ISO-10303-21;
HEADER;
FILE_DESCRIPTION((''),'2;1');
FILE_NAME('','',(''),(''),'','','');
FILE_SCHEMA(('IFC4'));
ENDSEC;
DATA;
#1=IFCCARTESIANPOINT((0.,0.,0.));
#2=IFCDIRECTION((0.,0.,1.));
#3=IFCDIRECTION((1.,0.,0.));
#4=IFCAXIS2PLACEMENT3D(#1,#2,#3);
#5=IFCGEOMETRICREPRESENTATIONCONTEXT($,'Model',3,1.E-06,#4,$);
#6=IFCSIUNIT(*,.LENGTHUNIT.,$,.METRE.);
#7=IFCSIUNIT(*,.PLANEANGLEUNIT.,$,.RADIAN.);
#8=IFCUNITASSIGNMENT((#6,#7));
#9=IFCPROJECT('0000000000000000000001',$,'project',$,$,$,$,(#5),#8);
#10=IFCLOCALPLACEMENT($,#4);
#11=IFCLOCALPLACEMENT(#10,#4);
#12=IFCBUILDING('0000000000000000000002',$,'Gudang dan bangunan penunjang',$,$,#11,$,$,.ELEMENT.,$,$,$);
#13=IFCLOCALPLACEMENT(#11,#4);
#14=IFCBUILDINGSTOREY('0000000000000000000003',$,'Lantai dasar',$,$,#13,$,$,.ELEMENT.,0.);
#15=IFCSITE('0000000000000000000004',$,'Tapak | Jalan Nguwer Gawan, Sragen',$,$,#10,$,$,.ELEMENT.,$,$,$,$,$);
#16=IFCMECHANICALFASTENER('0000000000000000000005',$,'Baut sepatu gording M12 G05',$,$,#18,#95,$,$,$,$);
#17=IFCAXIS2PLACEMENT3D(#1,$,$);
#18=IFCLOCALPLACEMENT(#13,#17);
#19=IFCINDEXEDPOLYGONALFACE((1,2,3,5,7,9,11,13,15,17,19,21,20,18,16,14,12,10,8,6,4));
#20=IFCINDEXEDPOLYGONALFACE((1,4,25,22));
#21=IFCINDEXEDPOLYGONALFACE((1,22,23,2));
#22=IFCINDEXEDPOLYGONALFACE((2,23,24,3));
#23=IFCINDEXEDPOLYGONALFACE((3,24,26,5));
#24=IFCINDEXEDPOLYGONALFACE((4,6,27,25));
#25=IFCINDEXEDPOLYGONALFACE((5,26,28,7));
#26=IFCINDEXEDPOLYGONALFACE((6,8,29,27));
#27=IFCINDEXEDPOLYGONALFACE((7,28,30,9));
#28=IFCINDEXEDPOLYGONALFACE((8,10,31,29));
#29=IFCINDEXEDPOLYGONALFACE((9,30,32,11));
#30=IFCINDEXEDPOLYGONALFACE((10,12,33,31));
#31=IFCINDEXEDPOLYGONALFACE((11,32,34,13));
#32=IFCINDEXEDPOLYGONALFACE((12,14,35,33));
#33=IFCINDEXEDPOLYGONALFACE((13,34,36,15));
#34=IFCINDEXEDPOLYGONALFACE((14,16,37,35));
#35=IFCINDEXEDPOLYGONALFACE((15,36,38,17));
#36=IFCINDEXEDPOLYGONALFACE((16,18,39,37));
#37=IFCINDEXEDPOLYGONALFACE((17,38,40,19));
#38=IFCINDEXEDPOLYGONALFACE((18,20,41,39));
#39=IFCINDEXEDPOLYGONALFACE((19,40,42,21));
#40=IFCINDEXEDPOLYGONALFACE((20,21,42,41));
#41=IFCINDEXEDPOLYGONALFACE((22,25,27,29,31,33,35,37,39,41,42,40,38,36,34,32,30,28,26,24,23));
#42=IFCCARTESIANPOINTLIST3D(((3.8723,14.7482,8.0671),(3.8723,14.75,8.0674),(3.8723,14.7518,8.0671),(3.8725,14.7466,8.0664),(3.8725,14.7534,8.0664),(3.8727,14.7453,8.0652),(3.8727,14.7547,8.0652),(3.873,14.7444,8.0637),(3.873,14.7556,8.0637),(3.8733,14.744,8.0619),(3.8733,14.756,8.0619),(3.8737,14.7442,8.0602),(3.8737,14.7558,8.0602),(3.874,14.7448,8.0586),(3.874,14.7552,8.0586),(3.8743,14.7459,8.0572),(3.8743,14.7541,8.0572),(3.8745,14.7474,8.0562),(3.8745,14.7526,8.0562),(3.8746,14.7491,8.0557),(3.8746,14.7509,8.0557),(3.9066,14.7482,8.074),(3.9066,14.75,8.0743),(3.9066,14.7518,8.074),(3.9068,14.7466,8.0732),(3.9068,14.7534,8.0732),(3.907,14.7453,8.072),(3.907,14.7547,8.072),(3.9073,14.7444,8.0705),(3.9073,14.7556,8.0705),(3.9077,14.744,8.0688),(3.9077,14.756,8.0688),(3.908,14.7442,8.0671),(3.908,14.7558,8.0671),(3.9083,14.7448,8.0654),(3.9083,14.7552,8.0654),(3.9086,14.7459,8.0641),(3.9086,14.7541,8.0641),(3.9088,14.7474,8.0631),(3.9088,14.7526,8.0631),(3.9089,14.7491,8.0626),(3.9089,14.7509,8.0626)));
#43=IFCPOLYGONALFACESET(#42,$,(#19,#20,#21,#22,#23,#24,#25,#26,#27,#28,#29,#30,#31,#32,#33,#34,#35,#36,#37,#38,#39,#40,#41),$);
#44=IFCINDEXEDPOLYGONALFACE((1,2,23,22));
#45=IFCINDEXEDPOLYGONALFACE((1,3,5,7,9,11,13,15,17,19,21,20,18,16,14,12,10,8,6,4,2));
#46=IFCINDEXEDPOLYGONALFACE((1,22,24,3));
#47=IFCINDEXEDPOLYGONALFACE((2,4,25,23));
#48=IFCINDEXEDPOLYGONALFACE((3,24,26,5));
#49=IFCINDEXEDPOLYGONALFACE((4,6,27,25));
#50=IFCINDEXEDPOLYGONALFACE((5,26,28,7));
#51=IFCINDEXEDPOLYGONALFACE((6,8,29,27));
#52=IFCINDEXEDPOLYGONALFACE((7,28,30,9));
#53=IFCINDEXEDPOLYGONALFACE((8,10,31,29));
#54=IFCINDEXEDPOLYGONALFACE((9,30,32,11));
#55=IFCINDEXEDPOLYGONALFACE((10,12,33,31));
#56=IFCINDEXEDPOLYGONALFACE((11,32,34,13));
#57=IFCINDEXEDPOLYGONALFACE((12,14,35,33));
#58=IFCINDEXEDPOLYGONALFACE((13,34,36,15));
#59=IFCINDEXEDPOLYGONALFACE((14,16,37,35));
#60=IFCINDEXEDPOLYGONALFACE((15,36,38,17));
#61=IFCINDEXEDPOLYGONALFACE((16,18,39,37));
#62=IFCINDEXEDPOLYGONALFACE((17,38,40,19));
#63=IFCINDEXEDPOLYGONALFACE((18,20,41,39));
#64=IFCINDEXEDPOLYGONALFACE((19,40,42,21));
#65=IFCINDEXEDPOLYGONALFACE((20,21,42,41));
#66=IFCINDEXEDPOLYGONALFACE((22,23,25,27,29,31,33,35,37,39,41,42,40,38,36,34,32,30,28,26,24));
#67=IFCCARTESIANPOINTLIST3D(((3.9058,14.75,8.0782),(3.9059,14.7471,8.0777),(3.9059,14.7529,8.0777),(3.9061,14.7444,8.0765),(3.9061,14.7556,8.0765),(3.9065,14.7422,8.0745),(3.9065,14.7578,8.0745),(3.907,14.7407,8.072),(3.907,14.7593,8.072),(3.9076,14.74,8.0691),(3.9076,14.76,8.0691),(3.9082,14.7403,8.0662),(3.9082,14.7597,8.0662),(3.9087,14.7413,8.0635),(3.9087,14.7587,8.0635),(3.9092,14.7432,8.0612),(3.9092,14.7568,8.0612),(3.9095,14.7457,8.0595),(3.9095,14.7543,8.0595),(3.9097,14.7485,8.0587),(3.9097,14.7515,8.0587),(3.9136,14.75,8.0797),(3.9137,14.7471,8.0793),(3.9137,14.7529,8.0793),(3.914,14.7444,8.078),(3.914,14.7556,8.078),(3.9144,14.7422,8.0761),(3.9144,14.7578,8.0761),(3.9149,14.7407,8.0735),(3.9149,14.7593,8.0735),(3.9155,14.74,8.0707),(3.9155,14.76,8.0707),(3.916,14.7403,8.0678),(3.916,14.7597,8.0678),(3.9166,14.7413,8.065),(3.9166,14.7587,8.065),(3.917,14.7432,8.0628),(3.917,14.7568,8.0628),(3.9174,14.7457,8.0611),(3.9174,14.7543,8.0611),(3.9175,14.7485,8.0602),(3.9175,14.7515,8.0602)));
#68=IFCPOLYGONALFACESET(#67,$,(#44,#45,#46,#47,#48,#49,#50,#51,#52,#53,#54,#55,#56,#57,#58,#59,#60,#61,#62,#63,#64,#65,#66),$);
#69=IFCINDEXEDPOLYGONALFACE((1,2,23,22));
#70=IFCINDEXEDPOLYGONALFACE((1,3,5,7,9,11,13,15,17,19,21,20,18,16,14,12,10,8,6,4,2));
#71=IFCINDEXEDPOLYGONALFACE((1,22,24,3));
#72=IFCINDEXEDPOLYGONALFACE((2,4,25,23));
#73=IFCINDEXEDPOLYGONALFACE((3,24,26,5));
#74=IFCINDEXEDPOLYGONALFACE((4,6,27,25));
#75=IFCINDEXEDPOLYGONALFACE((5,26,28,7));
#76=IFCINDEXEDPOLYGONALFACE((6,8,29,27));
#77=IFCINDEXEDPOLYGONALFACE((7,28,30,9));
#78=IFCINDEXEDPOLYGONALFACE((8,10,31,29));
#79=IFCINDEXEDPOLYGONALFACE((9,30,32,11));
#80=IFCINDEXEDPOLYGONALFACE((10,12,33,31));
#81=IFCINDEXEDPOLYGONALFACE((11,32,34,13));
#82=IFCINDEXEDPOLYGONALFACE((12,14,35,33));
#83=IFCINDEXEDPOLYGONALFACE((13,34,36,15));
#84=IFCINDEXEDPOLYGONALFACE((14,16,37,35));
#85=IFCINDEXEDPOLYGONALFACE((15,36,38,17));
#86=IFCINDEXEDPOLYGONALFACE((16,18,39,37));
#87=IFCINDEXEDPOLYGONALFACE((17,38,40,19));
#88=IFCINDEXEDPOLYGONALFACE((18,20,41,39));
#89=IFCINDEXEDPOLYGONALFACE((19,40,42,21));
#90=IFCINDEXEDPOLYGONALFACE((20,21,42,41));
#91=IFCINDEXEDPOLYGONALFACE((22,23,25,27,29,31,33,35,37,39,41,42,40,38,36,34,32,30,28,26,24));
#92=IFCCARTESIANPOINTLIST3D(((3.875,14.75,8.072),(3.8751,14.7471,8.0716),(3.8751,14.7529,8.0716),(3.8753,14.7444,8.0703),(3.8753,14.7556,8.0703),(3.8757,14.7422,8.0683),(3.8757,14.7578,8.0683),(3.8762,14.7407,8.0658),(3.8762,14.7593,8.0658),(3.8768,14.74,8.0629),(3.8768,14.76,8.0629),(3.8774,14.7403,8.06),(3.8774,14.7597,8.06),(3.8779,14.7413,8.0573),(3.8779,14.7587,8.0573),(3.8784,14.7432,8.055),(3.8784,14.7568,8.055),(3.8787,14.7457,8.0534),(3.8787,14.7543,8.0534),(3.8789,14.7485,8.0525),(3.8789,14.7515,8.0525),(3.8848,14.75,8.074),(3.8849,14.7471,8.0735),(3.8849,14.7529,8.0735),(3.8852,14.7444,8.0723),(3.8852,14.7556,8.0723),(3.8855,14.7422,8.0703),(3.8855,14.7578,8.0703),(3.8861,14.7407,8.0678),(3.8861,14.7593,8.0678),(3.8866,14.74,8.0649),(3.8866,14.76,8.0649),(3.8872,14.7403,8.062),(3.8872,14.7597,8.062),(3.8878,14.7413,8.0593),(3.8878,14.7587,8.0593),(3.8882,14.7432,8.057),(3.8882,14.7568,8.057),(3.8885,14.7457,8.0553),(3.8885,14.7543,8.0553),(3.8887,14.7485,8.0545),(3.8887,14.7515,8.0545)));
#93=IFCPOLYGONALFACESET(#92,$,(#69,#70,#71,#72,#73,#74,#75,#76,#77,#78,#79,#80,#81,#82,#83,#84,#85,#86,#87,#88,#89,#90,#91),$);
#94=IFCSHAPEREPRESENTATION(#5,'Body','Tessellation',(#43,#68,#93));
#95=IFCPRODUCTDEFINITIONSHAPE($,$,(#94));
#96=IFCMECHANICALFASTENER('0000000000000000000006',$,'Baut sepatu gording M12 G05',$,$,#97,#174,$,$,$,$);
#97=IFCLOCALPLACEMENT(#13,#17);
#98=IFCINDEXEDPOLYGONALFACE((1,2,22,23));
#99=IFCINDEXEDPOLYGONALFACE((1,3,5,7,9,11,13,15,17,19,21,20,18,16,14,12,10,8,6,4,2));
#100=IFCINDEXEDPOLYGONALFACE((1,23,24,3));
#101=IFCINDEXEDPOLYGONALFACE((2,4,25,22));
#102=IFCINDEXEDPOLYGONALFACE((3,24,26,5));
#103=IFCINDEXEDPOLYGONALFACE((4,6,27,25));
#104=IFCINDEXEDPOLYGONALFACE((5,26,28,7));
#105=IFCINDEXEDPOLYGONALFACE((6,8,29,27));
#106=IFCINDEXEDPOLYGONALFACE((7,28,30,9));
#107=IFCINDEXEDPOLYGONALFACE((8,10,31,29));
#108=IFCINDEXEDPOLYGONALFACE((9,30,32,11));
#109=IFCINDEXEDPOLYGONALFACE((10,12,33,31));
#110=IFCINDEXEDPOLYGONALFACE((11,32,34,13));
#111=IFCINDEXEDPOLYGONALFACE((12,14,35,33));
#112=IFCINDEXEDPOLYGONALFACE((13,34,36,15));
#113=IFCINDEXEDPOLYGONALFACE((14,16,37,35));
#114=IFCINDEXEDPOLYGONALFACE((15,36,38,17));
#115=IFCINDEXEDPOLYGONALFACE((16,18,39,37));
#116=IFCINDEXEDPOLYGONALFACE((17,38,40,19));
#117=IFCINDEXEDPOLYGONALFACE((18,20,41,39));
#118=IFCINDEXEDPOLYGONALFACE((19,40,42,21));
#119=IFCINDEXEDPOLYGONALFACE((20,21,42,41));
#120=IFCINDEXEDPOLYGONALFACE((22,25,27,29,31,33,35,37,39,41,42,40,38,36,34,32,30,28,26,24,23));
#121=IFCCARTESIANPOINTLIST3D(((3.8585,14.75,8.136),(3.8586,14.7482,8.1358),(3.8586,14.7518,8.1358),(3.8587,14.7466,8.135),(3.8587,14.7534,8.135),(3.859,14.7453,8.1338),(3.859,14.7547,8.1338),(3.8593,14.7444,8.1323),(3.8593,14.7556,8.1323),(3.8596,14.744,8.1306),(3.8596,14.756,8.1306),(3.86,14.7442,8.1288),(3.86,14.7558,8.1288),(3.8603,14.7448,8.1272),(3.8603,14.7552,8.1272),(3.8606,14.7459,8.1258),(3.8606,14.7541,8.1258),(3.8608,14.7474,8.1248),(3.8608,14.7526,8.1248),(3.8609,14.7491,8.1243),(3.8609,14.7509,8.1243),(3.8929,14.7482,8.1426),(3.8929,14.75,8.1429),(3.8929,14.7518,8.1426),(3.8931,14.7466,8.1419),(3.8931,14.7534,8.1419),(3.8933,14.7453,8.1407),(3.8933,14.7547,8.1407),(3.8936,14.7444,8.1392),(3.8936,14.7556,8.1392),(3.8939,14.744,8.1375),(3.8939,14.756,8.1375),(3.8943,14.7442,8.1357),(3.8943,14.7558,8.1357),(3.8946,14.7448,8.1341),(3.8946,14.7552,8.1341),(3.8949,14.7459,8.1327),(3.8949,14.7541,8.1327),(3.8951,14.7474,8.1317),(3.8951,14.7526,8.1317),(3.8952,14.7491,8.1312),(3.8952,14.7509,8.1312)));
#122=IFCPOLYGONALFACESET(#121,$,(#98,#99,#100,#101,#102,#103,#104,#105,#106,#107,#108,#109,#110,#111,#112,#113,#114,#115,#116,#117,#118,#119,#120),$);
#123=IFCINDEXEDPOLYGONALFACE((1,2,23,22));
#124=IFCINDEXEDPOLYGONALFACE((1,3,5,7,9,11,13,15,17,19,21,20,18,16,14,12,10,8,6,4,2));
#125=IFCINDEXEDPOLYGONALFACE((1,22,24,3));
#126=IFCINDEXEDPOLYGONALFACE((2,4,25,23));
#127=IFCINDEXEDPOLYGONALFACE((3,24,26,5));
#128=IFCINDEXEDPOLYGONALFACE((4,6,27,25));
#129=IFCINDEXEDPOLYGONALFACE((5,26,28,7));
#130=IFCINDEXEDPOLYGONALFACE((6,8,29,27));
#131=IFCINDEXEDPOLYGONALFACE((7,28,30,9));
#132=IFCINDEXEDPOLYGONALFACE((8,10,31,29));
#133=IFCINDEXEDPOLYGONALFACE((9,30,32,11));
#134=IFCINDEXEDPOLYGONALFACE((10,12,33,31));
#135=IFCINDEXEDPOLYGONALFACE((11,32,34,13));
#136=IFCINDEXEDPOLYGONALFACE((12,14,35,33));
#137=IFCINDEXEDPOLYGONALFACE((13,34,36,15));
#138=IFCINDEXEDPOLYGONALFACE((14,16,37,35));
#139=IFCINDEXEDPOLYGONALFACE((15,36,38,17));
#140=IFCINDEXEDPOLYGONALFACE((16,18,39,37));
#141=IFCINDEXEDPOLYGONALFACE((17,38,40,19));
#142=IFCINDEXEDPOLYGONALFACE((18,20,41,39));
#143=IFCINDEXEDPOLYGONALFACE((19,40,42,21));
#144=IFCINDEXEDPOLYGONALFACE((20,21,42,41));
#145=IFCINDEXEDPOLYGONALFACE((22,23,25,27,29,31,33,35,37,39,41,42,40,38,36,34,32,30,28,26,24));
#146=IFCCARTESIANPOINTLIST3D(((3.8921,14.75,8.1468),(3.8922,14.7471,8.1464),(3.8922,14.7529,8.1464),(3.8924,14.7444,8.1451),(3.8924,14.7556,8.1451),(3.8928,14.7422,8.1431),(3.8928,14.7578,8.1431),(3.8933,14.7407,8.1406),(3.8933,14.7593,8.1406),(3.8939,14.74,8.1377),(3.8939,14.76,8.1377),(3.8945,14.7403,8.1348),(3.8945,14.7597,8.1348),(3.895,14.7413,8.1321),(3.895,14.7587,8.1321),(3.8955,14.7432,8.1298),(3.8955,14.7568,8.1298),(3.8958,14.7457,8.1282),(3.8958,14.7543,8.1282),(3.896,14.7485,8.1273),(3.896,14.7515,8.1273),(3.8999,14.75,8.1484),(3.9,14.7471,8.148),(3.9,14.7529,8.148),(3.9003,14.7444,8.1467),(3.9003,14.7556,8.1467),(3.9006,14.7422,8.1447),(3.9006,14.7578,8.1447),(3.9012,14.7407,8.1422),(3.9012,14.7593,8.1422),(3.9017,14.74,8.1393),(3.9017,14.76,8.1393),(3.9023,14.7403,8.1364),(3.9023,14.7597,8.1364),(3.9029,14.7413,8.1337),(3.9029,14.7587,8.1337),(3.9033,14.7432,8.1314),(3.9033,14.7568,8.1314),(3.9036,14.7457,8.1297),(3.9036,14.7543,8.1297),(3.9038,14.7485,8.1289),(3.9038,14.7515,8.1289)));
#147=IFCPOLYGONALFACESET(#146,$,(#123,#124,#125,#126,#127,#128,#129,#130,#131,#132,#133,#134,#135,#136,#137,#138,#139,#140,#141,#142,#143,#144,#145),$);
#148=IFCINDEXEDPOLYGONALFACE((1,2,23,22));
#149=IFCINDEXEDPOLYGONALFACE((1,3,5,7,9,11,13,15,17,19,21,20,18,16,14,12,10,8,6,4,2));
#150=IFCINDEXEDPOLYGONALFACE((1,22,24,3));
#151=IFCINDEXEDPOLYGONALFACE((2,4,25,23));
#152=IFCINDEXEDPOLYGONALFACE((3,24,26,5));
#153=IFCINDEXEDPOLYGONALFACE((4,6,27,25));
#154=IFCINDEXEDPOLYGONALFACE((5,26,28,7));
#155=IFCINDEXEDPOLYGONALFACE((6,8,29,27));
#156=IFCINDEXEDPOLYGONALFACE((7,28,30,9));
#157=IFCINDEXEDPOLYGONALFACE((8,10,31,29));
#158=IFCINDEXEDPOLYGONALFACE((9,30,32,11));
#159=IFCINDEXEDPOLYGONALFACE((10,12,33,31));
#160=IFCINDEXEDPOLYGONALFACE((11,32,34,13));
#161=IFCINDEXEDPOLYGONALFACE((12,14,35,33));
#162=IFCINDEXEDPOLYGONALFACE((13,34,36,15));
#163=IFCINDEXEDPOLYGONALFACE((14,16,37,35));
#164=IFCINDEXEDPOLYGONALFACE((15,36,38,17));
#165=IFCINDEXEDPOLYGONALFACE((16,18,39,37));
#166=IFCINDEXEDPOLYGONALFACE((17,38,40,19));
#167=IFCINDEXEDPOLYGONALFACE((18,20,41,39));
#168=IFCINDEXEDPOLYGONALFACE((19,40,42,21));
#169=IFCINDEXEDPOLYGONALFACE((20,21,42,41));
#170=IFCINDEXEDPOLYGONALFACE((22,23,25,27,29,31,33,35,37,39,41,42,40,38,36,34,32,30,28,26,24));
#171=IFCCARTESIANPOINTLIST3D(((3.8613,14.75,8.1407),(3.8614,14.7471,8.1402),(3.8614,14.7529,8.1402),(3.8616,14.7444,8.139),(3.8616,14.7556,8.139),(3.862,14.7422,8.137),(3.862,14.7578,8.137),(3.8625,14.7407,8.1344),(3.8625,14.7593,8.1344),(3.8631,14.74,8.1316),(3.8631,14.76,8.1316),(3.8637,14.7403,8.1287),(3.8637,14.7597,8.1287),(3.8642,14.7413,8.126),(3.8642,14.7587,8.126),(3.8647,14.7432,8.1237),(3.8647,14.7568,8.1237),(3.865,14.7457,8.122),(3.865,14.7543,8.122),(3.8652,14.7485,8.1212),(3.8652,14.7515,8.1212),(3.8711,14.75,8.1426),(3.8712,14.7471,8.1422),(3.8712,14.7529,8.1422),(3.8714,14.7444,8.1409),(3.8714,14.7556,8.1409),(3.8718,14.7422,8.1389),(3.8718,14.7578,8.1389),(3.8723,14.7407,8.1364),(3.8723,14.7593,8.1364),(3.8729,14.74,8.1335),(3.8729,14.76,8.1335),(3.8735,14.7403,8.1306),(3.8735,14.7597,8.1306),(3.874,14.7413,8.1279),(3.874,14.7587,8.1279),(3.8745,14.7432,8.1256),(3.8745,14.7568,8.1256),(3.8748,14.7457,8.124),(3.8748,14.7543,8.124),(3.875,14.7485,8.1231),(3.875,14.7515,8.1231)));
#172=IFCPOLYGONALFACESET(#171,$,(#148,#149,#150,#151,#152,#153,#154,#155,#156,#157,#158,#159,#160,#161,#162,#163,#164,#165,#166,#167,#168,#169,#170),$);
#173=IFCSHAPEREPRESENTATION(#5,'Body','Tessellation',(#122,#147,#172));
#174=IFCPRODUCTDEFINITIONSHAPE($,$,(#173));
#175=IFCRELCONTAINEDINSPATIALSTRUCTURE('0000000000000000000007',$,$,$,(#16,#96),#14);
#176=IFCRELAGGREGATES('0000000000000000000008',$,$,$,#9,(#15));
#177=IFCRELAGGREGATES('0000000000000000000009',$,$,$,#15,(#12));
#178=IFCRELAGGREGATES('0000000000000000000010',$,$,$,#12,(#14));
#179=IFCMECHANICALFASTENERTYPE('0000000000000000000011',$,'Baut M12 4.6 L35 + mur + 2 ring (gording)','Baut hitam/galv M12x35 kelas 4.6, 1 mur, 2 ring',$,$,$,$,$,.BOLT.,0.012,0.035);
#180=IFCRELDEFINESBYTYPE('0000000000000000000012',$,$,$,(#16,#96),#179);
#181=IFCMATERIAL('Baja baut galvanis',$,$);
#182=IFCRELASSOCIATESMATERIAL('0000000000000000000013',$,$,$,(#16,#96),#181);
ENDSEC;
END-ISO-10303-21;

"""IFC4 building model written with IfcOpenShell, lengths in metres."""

from ifc_helpers import new_model, si_unit, frame, origin_with_axes, place, context, project, spatial, circle, extrude, source, transform, mapped, material, type_object, type_shapes, element, save


model = new_model("IFC4")

# Units and contexts
model_context = context("Model", 3, precision=1e-06, world=origin_with_axes())
ifc_project = project(units=[si_unit("LENGTHUNIT", "METRE"), si_unit("PLANEANGLEUNIT", "RADIAN")], contexts=[model_context])

# Site, building, storey
site_placement = place(None, origin_with_axes())
site = spatial("IfcSite", under=ifc_project, at=site_placement, Name="Tapak | Jalan Nguwer Gawan, Sragen", CompositionType="ELEMENT")
building_placement = place(site_placement, origin_with_axes())
building = spatial("IfcBuilding", under=site, at=building_placement, Name="Gudang dan bangunan penunjang", CompositionType="ELEMENT")
storey_placement = place(building_placement, origin_with_axes())
storey = spatial("IfcBuildingStorey", under=building, at=storey_placement, Name="Lantai dasar", CompositionType="ELEMENT", Elevation=0.0)

# Shared definitions
placement = place(None, origin_with_axes())

# Mechanical fasteners
ifc_material_1 = material(Name="Baja baut galvanis")
mechanical_fastener_type = type_object("IfcMechanicalFastenerType", Name="Baut M12 4.6 L35 + mur + 2 ring (gording)", Description="Baut hitam/galv M12x35 kelas 4.6, 1 mur, 2 ring", NominalDiameter=0.012, NominalLength=0.035, PredefinedType="BOLT")
shared_shape = source(origin_with_axes(), model_context, "Body", "SweptSolid", [
    extrude(circle(Radius=0.006), origin_with_axes(), (0.0, 0.0, 1.0), 0.035),
    extrude(circle(Radius=0.01), frame((0.0, 0.0, -0.008), z_axis=(0.0, 0.0, 1.0), x_axis=(1.0, 0.0, 0.0)), (0.0, 0.0, 1.0), 0.008),
    extrude(circle(Radius=0.01), frame((0.0, 0.0, 0.0214), z_axis=(0.0, 0.0, 1.0), x_axis=(1.0, 0.0, 0.0)), (0.0, 0.0, 1.0), 0.01),
])
type_shapes(mechanical_fastener_type, [shared_shape])
element("IfcMechanicalFastener", 1, at=placement, inside=storey, type_object=mechanical_fastener_type, material=ifc_material_1, Name="Baut sepatu gording M12 G05", context=model_context, shape_type="MappedRepresentation", body=[
    mapped(shared_shape, transform((3.9078, 14.75, 8.0684), x_axis=(-0.196116, 0.0, 0.980581), y_axis=(0.0, 1.0, 0.0), z_axis=(-0.980581, 0.0, -0.196116), scale=1.0)),
])
element("IfcMechanicalFastener", 2, at=placement, inside=storey, type_object=mechanical_fastener_type, material=ifc_material_1, Name="Baut sepatu gording M12 G05", context=model_context, shape_type="MappedRepresentation", body=[
    mapped(shared_shape, transform((3.894, 14.75, 8.137), x_axis=(-0.196116, 0.0, 0.980581), y_axis=(0.0, 1.0, 0.0), z_axis=(-0.980581, 0.0, -0.196116), scale=1.0)),
])

save(model, "model.ifc")
